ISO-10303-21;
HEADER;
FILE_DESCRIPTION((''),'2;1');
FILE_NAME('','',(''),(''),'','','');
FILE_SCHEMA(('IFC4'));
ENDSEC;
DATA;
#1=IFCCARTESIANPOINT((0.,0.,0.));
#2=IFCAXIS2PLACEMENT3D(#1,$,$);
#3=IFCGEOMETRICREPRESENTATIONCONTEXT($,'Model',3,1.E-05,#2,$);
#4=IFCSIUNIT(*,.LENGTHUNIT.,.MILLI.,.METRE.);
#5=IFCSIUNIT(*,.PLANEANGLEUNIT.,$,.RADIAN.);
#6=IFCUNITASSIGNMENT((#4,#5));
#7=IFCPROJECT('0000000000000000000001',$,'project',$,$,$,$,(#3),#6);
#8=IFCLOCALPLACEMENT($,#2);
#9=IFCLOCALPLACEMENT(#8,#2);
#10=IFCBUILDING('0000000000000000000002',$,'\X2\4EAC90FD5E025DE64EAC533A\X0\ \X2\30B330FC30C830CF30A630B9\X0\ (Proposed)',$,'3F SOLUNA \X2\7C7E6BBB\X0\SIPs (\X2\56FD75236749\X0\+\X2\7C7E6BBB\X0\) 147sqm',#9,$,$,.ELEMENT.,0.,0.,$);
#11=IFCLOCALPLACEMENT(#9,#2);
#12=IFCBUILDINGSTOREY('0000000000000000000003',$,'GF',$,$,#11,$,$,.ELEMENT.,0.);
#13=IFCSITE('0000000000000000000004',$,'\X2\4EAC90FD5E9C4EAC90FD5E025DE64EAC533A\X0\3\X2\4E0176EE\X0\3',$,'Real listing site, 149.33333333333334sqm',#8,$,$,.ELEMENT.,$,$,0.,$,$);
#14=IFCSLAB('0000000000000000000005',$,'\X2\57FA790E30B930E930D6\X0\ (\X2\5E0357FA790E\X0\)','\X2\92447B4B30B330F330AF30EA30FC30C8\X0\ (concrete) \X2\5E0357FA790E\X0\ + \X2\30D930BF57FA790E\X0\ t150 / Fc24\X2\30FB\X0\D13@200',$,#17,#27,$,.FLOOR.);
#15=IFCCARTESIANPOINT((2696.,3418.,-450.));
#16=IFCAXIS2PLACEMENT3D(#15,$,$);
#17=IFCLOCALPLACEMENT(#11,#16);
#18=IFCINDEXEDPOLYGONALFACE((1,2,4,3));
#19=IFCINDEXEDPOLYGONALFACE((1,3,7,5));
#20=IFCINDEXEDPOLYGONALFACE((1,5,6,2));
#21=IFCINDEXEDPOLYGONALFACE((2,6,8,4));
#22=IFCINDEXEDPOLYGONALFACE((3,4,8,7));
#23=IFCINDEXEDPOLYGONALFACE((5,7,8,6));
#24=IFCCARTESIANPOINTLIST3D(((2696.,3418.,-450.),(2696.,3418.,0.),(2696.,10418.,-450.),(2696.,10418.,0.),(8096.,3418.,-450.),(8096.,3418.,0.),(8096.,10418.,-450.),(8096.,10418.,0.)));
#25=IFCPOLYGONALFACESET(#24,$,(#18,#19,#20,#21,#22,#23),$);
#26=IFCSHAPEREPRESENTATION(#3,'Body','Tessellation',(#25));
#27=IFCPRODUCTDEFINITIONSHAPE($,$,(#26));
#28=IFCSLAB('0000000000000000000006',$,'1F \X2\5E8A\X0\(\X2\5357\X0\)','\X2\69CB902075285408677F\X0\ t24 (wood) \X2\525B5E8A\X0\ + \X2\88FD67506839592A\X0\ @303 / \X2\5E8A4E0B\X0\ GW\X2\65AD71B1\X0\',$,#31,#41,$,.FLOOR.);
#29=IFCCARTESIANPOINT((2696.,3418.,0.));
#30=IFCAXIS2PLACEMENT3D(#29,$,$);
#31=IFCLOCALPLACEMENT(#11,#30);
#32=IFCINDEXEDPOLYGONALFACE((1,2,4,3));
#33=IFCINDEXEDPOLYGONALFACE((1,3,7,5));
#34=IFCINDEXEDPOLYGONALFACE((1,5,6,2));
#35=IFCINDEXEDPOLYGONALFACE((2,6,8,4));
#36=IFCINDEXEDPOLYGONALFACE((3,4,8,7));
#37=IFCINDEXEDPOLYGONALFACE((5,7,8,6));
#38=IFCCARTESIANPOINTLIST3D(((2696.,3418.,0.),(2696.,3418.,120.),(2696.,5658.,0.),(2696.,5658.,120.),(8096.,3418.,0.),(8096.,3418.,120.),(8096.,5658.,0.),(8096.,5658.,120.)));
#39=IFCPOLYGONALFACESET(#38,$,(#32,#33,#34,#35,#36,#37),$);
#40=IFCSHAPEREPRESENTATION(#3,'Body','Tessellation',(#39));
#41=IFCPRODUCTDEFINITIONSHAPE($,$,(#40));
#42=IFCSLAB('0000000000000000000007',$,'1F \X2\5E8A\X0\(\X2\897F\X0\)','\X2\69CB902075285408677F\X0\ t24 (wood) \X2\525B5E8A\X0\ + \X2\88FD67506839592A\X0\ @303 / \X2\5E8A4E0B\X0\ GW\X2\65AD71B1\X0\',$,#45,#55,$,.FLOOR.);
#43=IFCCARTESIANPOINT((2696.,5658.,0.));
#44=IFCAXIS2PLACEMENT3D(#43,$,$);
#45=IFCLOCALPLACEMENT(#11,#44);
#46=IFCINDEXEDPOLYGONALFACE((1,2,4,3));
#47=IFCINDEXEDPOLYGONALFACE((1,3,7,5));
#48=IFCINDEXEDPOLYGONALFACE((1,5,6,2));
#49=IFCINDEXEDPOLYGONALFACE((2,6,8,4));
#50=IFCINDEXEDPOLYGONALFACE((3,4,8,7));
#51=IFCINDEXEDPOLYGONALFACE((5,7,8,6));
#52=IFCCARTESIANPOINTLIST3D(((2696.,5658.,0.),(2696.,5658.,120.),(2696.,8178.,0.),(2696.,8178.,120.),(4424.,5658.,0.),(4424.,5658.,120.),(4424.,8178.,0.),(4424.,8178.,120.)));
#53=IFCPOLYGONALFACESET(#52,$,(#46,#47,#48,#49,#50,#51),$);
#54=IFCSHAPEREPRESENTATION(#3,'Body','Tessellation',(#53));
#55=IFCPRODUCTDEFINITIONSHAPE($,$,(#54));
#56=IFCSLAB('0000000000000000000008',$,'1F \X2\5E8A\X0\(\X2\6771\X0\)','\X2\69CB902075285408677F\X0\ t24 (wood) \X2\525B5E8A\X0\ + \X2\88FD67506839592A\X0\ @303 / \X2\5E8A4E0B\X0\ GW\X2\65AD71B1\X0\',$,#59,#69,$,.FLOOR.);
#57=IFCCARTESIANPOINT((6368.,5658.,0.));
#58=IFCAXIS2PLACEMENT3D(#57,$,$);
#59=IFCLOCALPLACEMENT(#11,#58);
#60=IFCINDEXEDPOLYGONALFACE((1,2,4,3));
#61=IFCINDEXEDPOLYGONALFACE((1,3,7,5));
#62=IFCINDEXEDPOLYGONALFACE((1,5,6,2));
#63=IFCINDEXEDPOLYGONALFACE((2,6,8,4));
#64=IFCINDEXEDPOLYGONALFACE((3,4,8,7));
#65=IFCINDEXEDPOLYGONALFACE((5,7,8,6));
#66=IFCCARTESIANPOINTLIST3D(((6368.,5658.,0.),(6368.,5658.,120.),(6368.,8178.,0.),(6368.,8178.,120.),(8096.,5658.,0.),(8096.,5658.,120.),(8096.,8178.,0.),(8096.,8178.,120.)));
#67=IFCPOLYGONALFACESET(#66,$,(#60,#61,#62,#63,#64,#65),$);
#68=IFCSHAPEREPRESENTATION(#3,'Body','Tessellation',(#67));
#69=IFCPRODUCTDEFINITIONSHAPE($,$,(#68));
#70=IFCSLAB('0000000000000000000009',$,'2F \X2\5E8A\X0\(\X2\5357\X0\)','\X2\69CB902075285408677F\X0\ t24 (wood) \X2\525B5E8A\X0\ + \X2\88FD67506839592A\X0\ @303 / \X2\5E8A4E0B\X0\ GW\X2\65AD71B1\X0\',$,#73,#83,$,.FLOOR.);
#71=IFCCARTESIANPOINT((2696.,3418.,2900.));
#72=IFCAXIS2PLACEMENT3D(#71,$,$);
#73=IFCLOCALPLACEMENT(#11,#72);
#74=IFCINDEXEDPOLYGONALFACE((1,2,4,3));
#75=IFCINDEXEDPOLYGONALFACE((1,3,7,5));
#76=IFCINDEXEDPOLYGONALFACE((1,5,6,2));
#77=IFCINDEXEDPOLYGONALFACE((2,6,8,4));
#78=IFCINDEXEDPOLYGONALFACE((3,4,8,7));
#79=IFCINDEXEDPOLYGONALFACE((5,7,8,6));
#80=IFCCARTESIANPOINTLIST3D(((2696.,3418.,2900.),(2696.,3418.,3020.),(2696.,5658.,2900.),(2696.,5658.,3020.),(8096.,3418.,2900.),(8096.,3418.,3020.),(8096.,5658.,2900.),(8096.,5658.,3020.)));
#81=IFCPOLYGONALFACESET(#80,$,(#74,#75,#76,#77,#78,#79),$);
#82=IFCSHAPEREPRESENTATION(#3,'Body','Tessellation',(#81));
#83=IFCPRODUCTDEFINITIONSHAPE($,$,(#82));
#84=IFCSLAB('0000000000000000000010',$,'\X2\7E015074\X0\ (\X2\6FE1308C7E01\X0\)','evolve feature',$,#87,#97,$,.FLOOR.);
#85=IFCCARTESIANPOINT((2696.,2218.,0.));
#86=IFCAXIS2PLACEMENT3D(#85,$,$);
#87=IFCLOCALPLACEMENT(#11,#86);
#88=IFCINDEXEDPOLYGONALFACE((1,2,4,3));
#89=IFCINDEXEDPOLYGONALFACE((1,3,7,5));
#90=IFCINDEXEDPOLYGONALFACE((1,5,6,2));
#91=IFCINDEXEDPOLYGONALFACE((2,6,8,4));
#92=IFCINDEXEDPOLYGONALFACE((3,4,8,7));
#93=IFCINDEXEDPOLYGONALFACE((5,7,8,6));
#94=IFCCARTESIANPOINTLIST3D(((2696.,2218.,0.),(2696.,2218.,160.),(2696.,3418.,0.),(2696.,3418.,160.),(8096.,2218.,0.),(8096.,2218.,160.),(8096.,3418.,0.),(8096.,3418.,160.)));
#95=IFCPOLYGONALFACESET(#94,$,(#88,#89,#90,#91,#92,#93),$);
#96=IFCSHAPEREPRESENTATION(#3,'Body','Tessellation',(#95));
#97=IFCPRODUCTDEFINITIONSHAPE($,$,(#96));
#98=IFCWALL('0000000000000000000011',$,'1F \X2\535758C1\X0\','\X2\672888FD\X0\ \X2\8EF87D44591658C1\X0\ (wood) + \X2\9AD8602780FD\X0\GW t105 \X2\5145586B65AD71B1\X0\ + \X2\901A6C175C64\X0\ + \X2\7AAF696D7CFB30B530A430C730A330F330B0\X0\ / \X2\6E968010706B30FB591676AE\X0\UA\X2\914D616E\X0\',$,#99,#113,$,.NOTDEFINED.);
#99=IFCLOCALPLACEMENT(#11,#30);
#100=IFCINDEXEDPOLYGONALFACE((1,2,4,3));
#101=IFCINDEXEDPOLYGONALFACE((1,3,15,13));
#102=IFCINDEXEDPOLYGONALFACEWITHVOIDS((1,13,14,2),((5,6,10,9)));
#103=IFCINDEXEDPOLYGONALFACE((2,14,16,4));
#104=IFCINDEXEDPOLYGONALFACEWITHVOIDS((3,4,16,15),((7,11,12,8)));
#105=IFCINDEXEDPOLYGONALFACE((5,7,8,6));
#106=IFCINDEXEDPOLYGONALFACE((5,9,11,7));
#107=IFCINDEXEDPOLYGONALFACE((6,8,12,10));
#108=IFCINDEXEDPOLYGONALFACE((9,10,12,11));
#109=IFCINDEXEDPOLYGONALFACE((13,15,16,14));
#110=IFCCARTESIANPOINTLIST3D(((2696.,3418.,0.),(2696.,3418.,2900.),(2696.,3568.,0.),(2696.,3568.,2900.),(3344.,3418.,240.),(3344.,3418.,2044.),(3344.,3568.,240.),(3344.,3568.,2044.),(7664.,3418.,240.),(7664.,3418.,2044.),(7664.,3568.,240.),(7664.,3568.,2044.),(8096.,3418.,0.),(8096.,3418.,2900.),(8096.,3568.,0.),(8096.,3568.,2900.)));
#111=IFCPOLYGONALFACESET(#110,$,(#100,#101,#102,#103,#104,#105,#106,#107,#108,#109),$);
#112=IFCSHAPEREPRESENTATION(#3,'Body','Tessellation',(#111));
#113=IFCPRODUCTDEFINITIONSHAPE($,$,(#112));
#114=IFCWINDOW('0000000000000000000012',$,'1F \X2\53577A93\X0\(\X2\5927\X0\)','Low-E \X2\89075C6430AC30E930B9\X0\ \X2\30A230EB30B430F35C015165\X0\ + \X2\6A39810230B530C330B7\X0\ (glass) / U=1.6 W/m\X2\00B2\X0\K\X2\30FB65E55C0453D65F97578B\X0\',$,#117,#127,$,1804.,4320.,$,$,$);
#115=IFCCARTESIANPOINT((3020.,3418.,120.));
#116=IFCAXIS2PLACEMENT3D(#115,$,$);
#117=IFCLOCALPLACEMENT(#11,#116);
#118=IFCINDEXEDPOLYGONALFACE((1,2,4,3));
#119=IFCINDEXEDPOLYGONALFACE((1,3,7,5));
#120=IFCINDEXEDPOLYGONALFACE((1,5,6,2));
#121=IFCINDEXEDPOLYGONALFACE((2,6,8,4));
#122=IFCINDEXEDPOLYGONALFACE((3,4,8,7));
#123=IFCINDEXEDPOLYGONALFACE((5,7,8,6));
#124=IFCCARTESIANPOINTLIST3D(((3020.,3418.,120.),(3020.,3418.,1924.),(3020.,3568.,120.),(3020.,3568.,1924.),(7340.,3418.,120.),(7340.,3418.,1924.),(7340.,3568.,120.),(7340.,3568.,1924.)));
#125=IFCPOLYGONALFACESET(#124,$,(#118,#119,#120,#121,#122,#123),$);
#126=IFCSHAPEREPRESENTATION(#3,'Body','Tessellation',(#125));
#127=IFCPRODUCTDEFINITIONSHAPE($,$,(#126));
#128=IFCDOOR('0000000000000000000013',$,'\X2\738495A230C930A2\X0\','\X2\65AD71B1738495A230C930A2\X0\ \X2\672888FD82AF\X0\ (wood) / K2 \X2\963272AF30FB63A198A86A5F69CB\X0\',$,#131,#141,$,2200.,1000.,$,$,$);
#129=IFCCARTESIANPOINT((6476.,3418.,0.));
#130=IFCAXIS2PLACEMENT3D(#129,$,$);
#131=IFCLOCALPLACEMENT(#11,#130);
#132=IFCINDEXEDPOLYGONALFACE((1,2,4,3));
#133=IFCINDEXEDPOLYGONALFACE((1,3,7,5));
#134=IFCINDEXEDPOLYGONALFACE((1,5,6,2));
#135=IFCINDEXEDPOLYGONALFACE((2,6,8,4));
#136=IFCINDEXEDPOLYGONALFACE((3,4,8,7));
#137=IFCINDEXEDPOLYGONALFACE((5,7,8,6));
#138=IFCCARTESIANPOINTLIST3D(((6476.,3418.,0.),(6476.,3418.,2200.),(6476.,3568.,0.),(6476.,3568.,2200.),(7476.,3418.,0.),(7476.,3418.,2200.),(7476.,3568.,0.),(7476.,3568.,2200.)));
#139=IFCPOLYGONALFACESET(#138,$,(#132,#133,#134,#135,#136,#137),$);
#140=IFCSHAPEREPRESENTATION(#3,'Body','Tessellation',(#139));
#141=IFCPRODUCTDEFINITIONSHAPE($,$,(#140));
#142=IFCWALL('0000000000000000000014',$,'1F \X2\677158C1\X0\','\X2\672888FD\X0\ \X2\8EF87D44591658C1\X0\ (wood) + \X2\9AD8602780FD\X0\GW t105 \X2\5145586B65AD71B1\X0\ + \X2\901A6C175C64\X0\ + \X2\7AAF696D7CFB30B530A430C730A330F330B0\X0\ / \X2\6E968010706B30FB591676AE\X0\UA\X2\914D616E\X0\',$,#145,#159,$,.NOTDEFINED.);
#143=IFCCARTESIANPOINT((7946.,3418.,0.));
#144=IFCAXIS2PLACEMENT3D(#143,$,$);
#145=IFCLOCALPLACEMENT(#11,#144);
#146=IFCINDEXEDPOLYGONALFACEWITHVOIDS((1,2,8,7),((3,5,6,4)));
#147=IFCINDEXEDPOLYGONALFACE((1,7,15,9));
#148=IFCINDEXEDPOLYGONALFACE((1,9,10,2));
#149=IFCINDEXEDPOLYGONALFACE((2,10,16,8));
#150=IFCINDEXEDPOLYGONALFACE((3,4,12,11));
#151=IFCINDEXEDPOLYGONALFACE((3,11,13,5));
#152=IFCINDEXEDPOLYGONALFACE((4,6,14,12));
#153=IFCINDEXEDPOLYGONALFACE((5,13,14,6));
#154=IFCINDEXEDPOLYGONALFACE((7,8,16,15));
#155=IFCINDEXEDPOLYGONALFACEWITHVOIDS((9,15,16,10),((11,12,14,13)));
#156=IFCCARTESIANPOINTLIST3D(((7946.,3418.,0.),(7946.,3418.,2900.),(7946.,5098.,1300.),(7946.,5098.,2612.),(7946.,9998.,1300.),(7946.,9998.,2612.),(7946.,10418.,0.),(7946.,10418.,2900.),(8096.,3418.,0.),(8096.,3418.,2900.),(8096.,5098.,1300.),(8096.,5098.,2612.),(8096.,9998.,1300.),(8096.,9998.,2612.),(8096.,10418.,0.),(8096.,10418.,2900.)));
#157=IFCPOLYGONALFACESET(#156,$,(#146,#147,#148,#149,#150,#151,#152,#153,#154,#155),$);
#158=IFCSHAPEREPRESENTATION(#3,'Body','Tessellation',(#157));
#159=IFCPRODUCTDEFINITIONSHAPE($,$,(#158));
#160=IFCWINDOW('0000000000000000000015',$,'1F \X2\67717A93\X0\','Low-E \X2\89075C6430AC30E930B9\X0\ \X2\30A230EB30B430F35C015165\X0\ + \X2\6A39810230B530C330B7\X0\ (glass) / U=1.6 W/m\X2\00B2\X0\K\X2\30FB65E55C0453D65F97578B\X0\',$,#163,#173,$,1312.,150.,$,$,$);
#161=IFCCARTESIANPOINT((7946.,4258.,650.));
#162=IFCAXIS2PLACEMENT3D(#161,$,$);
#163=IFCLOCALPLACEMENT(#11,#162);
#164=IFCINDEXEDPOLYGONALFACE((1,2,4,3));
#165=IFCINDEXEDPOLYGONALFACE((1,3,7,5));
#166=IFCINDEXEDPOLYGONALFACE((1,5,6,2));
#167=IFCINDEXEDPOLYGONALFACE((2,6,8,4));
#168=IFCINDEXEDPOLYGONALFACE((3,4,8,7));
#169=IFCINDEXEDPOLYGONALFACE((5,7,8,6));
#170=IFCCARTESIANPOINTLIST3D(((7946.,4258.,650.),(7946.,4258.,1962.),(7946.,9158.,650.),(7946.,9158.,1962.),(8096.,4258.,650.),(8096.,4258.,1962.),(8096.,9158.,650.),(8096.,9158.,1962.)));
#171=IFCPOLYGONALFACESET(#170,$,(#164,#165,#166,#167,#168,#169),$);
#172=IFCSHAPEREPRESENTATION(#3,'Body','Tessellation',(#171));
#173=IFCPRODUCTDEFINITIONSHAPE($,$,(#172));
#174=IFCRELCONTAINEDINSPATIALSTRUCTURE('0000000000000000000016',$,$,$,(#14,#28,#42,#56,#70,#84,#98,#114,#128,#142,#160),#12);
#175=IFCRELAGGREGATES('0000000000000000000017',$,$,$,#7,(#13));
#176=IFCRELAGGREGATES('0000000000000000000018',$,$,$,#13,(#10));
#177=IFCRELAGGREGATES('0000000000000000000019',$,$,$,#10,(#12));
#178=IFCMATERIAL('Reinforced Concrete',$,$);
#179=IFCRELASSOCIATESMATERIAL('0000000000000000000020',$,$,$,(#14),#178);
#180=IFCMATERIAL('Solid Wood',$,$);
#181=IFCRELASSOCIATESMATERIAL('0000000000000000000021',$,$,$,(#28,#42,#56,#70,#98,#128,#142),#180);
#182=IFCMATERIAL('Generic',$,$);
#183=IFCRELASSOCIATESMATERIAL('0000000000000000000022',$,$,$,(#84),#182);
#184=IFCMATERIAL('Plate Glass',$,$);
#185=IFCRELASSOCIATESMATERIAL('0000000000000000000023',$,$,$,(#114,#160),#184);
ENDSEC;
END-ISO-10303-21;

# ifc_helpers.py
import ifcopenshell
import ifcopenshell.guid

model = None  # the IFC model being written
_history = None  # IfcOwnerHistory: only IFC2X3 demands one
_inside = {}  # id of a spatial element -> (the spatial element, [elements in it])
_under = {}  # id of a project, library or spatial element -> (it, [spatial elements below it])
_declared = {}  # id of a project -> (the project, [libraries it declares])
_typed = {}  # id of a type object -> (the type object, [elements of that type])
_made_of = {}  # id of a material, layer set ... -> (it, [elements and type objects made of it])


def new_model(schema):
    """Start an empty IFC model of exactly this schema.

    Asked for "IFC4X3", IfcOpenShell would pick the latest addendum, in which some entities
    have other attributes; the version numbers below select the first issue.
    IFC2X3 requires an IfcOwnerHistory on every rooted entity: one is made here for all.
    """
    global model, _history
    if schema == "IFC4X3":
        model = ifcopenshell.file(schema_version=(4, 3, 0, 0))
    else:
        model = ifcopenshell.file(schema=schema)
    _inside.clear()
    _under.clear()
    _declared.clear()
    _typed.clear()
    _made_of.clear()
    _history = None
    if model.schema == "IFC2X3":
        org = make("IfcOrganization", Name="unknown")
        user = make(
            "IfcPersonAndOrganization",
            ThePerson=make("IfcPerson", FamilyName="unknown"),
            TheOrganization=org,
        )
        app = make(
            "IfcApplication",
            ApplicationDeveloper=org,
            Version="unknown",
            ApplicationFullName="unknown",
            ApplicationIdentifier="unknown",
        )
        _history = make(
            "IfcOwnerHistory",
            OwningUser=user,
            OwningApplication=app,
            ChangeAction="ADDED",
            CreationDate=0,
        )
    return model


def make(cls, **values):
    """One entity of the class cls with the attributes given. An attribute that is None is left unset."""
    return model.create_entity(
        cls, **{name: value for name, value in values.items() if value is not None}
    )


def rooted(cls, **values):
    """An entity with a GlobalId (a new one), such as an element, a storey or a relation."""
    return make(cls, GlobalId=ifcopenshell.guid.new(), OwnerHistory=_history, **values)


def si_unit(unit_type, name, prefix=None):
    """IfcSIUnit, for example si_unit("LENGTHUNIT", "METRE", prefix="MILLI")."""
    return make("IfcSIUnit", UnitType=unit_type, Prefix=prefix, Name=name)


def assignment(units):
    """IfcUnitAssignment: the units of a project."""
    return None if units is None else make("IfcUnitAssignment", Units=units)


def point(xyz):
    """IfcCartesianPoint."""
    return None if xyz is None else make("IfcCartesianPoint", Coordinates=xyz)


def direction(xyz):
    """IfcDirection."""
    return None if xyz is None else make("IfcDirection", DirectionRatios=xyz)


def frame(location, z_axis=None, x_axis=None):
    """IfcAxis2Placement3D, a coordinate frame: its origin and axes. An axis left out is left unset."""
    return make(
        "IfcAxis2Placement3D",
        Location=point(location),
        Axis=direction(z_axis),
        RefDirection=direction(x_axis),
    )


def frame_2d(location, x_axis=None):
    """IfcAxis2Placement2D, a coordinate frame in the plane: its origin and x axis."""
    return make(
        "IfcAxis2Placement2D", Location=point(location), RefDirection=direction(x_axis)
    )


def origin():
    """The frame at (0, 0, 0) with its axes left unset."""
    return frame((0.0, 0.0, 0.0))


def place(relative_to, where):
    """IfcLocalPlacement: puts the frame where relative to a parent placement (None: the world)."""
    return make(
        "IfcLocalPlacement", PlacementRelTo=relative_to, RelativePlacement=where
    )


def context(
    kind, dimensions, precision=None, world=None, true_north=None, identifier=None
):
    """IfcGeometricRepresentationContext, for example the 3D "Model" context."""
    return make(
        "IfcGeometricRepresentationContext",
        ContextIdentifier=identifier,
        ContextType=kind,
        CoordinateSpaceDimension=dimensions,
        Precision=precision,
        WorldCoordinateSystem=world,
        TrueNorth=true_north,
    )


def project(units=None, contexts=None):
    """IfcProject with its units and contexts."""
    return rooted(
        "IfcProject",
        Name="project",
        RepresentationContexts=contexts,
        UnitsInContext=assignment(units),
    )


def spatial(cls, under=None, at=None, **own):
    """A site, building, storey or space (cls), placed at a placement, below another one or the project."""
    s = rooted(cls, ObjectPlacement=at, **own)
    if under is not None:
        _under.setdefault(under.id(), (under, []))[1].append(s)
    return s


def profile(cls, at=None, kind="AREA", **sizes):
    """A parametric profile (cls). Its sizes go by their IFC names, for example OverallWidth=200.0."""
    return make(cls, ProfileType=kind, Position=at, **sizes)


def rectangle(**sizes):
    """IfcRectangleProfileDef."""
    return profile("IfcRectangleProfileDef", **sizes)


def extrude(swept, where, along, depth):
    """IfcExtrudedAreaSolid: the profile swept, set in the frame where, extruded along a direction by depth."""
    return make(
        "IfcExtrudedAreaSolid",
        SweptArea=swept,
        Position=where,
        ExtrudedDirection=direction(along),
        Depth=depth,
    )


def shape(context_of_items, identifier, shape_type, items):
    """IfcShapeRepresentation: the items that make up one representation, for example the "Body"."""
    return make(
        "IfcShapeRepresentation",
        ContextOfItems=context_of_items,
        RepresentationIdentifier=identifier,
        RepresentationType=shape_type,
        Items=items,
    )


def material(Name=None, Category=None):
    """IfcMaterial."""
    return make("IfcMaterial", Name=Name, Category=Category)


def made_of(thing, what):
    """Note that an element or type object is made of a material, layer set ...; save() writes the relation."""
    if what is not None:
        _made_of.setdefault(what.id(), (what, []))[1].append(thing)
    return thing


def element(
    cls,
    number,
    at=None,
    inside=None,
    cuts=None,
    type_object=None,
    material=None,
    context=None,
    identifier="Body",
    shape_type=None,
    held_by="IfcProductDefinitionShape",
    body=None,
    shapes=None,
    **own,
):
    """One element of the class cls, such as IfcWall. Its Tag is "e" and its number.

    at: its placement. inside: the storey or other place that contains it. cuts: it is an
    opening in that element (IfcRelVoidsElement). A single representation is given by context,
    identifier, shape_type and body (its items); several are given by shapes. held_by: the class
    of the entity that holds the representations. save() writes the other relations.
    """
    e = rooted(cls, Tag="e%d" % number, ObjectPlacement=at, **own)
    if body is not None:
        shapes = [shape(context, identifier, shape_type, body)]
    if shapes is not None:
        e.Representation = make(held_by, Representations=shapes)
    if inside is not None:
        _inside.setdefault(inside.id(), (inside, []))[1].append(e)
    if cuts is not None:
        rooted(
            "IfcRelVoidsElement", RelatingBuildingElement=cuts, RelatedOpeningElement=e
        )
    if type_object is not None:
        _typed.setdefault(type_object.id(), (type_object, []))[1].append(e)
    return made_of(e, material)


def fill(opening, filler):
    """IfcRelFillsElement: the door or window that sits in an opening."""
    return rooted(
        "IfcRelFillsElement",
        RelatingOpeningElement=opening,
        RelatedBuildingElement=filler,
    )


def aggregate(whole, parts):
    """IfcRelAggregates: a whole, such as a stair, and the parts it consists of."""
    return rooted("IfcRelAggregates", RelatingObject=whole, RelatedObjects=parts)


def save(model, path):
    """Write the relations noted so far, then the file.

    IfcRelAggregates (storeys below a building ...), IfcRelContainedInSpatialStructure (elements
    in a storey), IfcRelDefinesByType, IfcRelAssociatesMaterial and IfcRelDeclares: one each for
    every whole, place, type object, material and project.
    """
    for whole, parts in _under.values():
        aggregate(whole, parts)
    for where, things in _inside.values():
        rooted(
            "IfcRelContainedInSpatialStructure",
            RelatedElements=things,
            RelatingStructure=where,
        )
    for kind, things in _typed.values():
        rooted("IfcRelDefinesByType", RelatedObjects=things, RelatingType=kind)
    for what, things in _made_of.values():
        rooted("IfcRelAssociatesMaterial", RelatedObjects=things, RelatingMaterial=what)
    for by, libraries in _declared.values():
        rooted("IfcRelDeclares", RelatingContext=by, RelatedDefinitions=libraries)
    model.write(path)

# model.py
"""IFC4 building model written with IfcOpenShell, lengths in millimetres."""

from ifc_helpers import new_model, si_unit, frame, frame_2d, origin, place, context, project, spatial, rectangle, extrude, material, element, fill, save


model = new_model("IFC4")

# Units and contexts
model_context = context("Model", 3, precision=1e-05, world=origin())
ifc_project = project(units=[si_unit("LENGTHUNIT", "METRE", prefix="MILLI"), si_unit("PLANEANGLEUNIT", "RADIAN")], contexts=[model_context])

# Site, building, storey
site_placement = place(None, origin())
site = spatial("IfcSite", under=ifc_project, at=site_placement, Name="京都府京都市左京区3丁目3", ObjectType="Real listing site, 149.33333333333334sqm", CompositionType="ELEMENT", RefElevation=0.0)
building_placement = place(site_placement, origin())
building = spatial("IfcBuilding", under=site, at=building_placement, Name="京都市左京区 コートハウス (Proposed)", ObjectType="3F SOLUNA 籾殻SIPs (国産杉+籾殻) 147sqm", CompositionType="ELEMENT", ElevationOfRefHeight=0.0, ElevationOfTerrain=0.0)
storey_placement = place(building_placement, origin())
storey = spatial("IfcBuildingStorey", under=building, at=storey_placement, Name="GF", CompositionType="ELEMENT", Elevation=0.0)

# Slabs
ifc_material_1 = material(Name="Reinforced Concrete")
slab_1_placement = place(storey_placement, frame((2696.0, 3418.0, -450.0)))
element("IfcSlab", 1, at=slab_1_placement, inside=storey, material=ifc_material_1, Name="基礎スラブ (布基礎)", Description="鉄筋コンクリート (concrete) 布基礎 + ベタ基礎 t150 / Fc24・D13@200", PredefinedType="FLOOR", context=model_context, shape_type="SweptSolid", body=[
    extrude(rectangle(XDim=5400.0, YDim=7000.0, at=frame_2d((2700.0, 3500.0))), frame((2696.0, 3418.0, -450.0)), (0.0, 0.0, 1.0), 450.0),
])
ifc_material_2 = material(Name="Solid Wood")
slab_2_placement = place(storey_placement, frame((2696.0, 3418.0, 0.0)))
element("IfcSlab", 2, at=slab_2_placement, inside=storey, material=ifc_material_2, Name="1F 床(南)", Description="構造用合板 t24 (wood) 剛床 + 製材根太 @303 / 床下 GW断熱", PredefinedType="FLOOR", context=model_context, shape_type="SweptSolid", body=[
    extrude(rectangle(XDim=5400.0, YDim=2240.0, at=frame_2d((2700.0, 1120.0))), frame((2696.0, 3418.0, 0.0)), (0.0, 0.0, 1.0), 120.0),
])
slab_3_placement = place(storey_placement, frame((2696.0, 5658.0, 0.0)))
element("IfcSlab", 3, at=slab_3_placement, inside=storey, material=ifc_material_2, Name="1F 床(西)", Description="構造用合板 t24 (wood) 剛床 + 製材根太 @303 / 床下 GW断熱", PredefinedType="FLOOR", context=model_context, shape_type="SweptSolid", body=[
    extrude(rectangle(XDim=1728.0, YDim=2520.0, at=frame_2d((864.0, 1260.0))), frame((2696.0, 5658.0, 0.0)), (0.0, 0.0, 1.0), 120.0),
])
slab_4_placement = place(storey_placement, frame((6368.0, 5658.0, 0.0)))
element("IfcSlab", 4, at=slab_4_placement, inside=storey, material=ifc_material_2, Name="1F 床(東)", Description="構造用合板 t24 (wood) 剛床 + 製材根太 @303 / 床下 GW断熱", PredefinedType="FLOOR", context=model_context, shape_type="SweptSolid", body=[
    extrude(rectangle(XDim=1728.0, YDim=2520.0, at=frame_2d((864.0, 1260.0))), frame((6368.0, 5658.0, 0.0)), (0.0, 0.0, 1.0), 120.0),
])
slab_5_placement = place(storey_placement, frame((2696.0, 3418.0, 2900.0)))
element("IfcSlab", 5, at=slab_5_placement, inside=storey, material=ifc_material_2, Name="2F 床(南)", Description="構造用合板 t24 (wood) 剛床 + 製材根太 @303 / 床下 GW断熱", PredefinedType="FLOOR", context=model_context, shape_type="SweptSolid", body=[
    extrude(rectangle(XDim=5400.0, YDim=2240.0, at=frame_2d((2700.0, 1120.0))), frame((2696.0, 3418.0, 2900.0)), (0.0, 0.0, 1.0), 120.0),
])
ifc_material_3 = material(Name="Generic")
slab_6_placement = place(storey_placement, frame((2696.0, 2218.0, 0.0)))
element("IfcSlab", 6, at=slab_6_placement, inside=storey, material=ifc_material_3, Name="縁側 (濡れ縁)", Description="evolve feature", PredefinedType="FLOOR", context=model_context, shape_type="SweptSolid", body=[
    extrude(rectangle(XDim=5400.0, YDim=1200.0, at=frame_2d((2700.0, 600.0))), frame((2696.0, 2218.0, 0.0)), (0.0, 0.0, 1.0), 160.0),
])

# Wall, openings, window, door
wall_1_placement = place(storey_placement, frame((2696.0, 3418.0, 0.0)))
wall_1 = element("IfcWall", 7, at=wall_1_placement, inside=storey, material=ifc_material_2, Name="1F 南壁", Description="木製 軸組外壁 (wood) + 高性能GW t105 充填断熱 + 通気層 + 窯業系サイディング / 準耐火・外皮UA配慮", PredefinedType="NOTDEFINED", context=model_context, shape_type="SweptSolid", body=[
    extrude(rectangle(XDim=5400.0, YDim=150.0, at=frame_2d((2700.0, 75.0))), frame((2696.0, 3418.0, 0.0)), (0.0, 0.0, 1.0), 2900.0),
])
opening_1_placement = place(storey_placement, frame((3020.0, 3418.0, 120.0)))
opening_1 = element("IfcOpeningElement", 8, at=opening_1_placement, cuts=wall_1, PredefinedType="NOTDEFINED", context=model_context, shape_type="SweptSolid", body=[
    extrude(rectangle(XDim=4320.0, YDim=150.0, at=frame_2d((2160.0, 75.0))), frame((3020.0, 3418.0, 120.0)), (0.0, 0.0, 1.0), 1804.0),
])
opening_2_placement = place(storey_placement, frame((6476.0, 3418.0, 0.0)))
opening_2 = element("IfcOpeningElement", 9, at=opening_2_placement, cuts=wall_1, PredefinedType="NOTDEFINED", context=model_context, shape_type="SweptSolid", body=[
    extrude(rectangle(XDim=1000.0, YDim=150.0, at=frame_2d((500.0, 75.0))), frame((6476.0, 3418.0, 0.0)), (0.0, 0.0, 1.0), 2200.0),
])
ifc_material_4 = material(Name="Plate Glass")
window_1_placement = place(storey_placement, frame((3020.0, 3418.0, 120.0)))
window_1 = element("IfcWindow", 10, at=window_1_placement, inside=storey, material=ifc_material_4, Name="1F 南窓(大)", Description="Low-E 複層ガラス アルゴン封入 + 樹脂サッシ (glass) / U=1.6 W/m²K・日射取得型", OverallHeight=1804.0, OverallWidth=4320.0, context=model_context, shape_type="SweptSolid", body=[
    extrude(rectangle(XDim=4320.0, YDim=150.0, at=frame_2d((2160.0, 75.0))), frame((3020.0, 3418.0, 120.0)), (0.0, 0.0, 1.0), 1804.0),
])
fill(opening_1, window_1)
door_placement = place(storey_placement, frame((6476.0, 3418.0, 0.0)))
door = element("IfcDoor", 11, at=door_placement, inside=storey, material=ifc_material_2, Name="玄関ドア", Description="断熱玄関ドア 木製芯 (wood) / K2 防犯・採風機構", OverallHeight=2200.0, OverallWidth=1000.0, context=model_context, shape_type="SweptSolid", body=[
    extrude(rectangle(XDim=1000.0, YDim=150.0, at=frame_2d((500.0, 75.0))), frame((6476.0, 3418.0, 0.0)), (0.0, 0.0, 1.0), 2200.0),
])
fill(opening_2, door)

# Wall, opening, window
wall_2_placement = place(storey_placement, frame((7946.0, 3418.0, 0.0)))
wall_2 = element("IfcWall", 12, at=wall_2_placement, inside=storey, material=ifc_material_2, Name="1F 東壁", Description="木製 軸組外壁 (wood) + 高性能GW t105 充填断熱 + 通気層 + 窯業系サイディング / 準耐火・外皮UA配慮", PredefinedType="NOTDEFINED", context=model_context, shape_type="SweptSolid", body=[
    extrude(rectangle(XDim=150.0, YDim=7000.0, at=frame_2d((75.0, 3500.0))), frame((7946.0, 3418.0, 0.0)), (0.0, 0.0, 1.0), 2900.0),
])
opening_3_placement = place(storey_placement, frame((7946.0, 4258.0, 650.0)))
opening_3 = element("IfcOpeningElement", 13, at=opening_3_placement, cuts=wall_2, PredefinedType="NOTDEFINED", context=model_context, shape_type="SweptSolid", body=[
    extrude(rectangle(XDim=150.0, YDim=4900.0, at=frame_2d((75.0, 2450.0))), frame((7946.0, 4258.0, 650.0)), (0.0, 0.0, 1.0), 1312.0),
])
window_2_placement = place(storey_placement, frame((7946.0, 4258.0, 650.0)))
window_2 = element("IfcWindow", 14, at=window_2_placement, inside=storey, material=ifc_material_4, Name="1F 東窓", Description="Low-E 複層ガラス アルゴン封入 + 樹脂サッシ (glass) / U=1.6 W/m²K・日射取得型", OverallHeight=1312.0, OverallWidth=150.0, context=model_context, shape_type="SweptSolid", body=[
    extrude(rectangle(XDim=150.0, YDim=4900.0, at=frame_2d((75.0, 2450.0))), frame((7946.0, 4258.0, 650.0)), (0.0, 0.0, 1.0), 1312.0),
])
fill(opening_3, window_2)

save(model, "model.ifc")
